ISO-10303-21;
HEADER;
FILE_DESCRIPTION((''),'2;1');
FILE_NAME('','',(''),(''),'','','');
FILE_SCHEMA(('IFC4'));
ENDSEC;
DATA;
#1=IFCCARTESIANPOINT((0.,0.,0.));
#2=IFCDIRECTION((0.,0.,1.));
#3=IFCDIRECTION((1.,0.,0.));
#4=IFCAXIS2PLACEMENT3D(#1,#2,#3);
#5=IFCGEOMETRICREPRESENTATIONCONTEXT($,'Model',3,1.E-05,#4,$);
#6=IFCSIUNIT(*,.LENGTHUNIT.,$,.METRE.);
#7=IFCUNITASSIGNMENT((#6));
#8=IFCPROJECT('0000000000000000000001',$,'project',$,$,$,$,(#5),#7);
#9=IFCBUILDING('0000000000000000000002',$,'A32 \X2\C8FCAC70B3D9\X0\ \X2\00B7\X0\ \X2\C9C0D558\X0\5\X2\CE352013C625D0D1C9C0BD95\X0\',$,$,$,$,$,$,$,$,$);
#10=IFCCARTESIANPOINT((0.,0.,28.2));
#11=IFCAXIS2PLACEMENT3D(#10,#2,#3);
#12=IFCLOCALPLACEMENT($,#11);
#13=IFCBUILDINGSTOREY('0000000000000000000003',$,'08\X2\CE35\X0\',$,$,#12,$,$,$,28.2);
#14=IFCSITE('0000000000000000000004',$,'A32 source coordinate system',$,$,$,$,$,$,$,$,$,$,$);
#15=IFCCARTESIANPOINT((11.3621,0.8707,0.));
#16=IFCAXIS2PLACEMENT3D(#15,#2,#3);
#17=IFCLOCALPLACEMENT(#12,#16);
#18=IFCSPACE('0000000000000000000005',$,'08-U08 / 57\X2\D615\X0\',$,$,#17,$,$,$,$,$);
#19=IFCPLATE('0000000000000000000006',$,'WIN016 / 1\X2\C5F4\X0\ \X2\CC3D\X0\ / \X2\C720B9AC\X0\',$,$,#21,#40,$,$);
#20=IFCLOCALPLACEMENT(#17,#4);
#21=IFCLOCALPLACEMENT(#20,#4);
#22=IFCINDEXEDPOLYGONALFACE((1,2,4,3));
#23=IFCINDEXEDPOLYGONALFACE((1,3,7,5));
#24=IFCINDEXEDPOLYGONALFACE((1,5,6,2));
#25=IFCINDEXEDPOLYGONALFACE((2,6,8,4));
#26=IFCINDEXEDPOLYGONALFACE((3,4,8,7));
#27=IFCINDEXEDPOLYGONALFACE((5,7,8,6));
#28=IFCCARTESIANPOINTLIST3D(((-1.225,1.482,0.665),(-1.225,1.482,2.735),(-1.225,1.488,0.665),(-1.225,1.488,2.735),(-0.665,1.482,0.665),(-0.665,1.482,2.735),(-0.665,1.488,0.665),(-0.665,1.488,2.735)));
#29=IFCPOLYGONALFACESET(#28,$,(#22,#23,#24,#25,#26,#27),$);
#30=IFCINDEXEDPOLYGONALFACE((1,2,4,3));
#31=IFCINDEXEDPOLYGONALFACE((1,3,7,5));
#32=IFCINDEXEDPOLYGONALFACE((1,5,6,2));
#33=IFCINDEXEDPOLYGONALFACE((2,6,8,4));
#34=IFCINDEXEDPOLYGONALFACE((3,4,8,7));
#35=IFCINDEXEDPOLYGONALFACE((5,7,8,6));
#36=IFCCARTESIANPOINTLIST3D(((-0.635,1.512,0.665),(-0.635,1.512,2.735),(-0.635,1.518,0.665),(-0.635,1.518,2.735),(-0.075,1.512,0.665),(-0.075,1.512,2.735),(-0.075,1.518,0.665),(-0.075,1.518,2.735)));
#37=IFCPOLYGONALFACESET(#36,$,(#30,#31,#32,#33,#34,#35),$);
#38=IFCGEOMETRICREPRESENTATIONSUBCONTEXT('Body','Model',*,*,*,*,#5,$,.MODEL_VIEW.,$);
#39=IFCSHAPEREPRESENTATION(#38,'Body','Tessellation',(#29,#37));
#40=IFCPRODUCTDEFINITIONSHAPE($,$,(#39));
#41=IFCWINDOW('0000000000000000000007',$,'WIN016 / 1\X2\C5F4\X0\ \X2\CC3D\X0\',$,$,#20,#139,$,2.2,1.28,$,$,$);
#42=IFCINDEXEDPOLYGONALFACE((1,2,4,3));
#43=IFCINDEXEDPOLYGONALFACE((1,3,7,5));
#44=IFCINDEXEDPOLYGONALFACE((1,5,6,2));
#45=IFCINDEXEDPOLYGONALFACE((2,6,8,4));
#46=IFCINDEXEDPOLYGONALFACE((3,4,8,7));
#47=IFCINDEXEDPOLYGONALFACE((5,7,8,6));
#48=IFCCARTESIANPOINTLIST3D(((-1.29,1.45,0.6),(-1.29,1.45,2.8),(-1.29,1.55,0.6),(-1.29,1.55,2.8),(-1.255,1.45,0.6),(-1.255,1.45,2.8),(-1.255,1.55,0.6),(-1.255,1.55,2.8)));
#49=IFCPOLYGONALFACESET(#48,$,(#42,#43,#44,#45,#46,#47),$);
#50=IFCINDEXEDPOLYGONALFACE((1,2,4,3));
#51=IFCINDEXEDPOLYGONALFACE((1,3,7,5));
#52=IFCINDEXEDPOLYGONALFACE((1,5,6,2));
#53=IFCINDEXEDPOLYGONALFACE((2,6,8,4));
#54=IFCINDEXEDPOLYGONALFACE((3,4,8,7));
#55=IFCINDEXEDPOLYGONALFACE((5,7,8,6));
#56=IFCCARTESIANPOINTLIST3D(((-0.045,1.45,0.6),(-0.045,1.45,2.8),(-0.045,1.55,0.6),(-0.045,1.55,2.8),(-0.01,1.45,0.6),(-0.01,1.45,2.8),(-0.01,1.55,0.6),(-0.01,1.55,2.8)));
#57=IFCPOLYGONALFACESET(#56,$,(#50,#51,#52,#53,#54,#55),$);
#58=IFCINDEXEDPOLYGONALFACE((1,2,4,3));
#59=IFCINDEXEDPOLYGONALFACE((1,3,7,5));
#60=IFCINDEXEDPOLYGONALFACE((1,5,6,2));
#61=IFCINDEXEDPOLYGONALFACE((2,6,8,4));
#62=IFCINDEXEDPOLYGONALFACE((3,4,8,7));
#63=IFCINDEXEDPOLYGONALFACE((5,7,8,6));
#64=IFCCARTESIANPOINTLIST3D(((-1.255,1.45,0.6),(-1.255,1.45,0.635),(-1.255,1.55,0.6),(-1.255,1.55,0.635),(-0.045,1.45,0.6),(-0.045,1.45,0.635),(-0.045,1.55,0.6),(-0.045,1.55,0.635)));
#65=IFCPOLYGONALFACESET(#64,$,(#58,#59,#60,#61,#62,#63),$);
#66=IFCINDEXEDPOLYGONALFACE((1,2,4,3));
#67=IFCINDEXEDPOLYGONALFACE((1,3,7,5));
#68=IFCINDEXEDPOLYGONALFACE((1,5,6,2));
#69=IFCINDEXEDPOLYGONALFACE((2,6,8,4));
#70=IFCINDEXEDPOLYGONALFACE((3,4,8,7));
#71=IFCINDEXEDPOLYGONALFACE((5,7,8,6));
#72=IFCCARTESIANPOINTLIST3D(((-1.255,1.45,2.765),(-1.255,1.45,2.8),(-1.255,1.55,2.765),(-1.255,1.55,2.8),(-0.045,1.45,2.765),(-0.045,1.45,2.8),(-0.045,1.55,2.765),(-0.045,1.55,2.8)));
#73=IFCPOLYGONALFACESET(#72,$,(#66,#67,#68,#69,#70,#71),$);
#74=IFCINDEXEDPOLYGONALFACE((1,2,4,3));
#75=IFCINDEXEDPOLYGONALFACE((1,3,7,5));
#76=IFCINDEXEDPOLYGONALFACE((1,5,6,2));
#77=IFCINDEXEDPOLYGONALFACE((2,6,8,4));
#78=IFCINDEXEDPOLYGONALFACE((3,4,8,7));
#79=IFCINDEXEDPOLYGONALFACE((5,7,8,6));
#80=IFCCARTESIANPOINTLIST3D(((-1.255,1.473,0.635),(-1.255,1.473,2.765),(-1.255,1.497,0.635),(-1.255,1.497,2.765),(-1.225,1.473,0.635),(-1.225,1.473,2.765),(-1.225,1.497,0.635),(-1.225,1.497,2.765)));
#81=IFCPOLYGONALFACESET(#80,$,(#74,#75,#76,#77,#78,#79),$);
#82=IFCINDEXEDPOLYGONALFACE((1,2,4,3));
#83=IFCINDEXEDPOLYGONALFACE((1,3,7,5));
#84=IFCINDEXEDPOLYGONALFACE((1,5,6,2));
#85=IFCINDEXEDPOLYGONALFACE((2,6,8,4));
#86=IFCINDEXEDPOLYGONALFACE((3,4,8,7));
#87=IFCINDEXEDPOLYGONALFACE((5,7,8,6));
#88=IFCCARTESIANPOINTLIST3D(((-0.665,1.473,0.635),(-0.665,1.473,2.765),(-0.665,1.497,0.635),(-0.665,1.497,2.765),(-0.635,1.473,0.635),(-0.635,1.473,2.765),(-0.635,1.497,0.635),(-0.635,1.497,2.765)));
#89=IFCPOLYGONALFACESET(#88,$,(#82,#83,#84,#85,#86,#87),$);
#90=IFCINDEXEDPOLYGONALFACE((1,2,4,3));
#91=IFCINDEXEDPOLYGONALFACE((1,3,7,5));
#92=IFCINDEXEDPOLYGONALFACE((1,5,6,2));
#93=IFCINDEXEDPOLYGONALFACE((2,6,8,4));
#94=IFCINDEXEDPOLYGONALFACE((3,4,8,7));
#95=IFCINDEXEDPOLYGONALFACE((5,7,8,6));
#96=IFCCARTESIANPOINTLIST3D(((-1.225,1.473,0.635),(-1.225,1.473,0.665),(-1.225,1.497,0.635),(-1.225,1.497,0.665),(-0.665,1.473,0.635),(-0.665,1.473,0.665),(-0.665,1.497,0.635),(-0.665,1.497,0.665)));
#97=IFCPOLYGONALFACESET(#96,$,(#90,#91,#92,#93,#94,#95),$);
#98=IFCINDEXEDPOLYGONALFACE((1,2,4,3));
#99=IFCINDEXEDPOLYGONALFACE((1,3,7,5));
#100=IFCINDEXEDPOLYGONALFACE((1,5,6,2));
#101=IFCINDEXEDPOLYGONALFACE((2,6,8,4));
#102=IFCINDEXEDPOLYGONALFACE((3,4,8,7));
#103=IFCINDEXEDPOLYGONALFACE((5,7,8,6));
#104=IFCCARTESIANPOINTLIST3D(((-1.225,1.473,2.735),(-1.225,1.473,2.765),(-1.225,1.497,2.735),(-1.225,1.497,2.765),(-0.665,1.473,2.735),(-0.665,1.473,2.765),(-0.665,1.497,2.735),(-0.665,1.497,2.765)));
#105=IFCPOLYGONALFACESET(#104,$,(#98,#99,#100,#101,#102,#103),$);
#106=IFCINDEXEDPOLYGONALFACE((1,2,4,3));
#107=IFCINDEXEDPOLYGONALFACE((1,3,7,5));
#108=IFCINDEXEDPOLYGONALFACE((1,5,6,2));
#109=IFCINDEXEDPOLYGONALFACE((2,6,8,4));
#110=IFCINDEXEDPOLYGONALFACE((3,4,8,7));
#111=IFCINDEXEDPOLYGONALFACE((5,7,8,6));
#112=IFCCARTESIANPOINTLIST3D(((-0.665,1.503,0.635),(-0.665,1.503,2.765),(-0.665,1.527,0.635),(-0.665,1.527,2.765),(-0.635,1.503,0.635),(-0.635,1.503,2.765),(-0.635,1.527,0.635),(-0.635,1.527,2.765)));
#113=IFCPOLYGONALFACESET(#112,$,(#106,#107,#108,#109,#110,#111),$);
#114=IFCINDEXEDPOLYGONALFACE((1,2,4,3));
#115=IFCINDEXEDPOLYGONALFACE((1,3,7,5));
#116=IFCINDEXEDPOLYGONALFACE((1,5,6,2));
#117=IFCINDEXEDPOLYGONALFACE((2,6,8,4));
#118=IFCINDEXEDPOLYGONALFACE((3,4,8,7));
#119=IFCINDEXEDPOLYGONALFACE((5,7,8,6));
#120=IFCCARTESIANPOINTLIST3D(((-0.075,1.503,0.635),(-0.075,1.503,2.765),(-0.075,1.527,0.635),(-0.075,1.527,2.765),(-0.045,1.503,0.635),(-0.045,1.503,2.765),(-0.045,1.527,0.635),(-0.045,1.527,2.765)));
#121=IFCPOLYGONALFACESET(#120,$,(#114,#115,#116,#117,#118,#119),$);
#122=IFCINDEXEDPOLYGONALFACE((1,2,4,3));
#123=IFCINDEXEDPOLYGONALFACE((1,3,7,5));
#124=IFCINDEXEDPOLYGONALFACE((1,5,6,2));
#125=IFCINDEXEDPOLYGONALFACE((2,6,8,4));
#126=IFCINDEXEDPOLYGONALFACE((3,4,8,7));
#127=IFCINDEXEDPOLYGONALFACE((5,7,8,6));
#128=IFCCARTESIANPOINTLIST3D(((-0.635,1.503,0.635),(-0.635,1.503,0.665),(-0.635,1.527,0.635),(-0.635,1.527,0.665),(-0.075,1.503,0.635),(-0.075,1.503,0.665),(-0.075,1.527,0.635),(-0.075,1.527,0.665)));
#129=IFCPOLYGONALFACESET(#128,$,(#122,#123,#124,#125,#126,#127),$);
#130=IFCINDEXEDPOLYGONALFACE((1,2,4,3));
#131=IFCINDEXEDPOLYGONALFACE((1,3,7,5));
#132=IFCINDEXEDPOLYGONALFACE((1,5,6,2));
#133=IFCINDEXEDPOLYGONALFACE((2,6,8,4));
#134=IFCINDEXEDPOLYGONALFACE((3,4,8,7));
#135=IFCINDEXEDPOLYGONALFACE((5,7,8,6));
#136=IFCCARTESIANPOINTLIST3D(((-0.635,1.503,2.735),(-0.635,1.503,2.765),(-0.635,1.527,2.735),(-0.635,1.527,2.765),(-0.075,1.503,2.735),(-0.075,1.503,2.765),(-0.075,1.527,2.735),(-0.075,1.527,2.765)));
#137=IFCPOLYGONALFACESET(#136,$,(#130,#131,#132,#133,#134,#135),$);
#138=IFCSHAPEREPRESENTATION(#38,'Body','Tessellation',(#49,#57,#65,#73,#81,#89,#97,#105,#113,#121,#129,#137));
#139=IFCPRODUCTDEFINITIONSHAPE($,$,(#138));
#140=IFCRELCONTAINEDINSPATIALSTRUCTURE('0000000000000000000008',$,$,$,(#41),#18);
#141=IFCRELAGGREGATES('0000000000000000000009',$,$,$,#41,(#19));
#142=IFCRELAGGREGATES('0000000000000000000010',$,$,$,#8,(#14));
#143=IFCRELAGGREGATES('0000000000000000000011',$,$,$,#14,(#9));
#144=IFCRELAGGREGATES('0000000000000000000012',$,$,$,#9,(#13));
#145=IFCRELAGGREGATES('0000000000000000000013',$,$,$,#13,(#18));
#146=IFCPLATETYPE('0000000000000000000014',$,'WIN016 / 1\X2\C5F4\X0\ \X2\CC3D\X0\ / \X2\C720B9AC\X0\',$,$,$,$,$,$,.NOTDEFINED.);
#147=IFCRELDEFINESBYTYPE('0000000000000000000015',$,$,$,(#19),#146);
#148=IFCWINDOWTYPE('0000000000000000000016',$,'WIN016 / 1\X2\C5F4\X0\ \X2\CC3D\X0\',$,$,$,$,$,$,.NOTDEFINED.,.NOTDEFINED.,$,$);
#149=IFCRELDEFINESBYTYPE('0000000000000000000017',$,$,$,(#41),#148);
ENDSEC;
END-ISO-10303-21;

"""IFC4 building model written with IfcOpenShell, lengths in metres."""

from ifc_helpers import new_model, si_unit, frame, origin, origin_with_axes, place, context, subcontext, project, spatial, polyline, outline, extrude, source, transform, mapped, type_object, type_shapes, element, aggregate, save


model = new_model("IFC4")

# Units and contexts
model_context = context("Model", 3, precision=1e-05, world=origin_with_axes())
body_context = subcontext(model_context, "Body", "Model", "MODEL_VIEW")
ifc_project = project(units=[si_unit("LENGTHUNIT", "METRE")], contexts=[model_context])

# Plate
storey_placement = place(None, frame((0.0, 0.0, 28.2), z_axis=(0.0, 0.0, 1.0), x_axis=(1.0, 0.0, 0.0)))
space_placement = place(storey_placement, frame((11.3621, 0.8707, 0.0), z_axis=(0.0, 0.0, 1.0), x_axis=(1.0, 0.0, 0.0)))
plate_type_1 = type_object("IfcPlateType", Name="WIN016 / 1열 창 / 유리", PredefinedType="NOTDEFINED")
shared_shape_1 = source(origin(), body_context, "Body", "SweptSolid", [
    extrude(outline(polyline([(-1.225, 1.482), (-1.225, 1.488), (-0.665, 1.488), (-0.665, 1.482), (-1.225, 1.482)])), frame((0.0, 0.0, 0.665)), (0.0, 0.0, 1.0), 2.07),
    extrude(outline(polyline([(-0.635, 1.512), (-0.635, 1.518), (-0.075, 1.518), (-0.075, 1.512), (-0.635, 1.512)])), frame((0.0, 0.0, 0.665)), (0.0, 0.0, 1.0), 2.07),
])
type_shapes(plate_type_1, [shared_shape_1])
window_1_placement = place(space_placement, origin_with_axes())
plate_1_placement = place(window_1_placement, origin_with_axes())
plate_1 = element("IfcPlate", 1, at=plate_1_placement, type_object=plate_type_1, Name="WIN016 / 1열 창 / 유리", context=body_context, shape_type="MappedRepresentation", body=[
    mapped(shared_shape_1, transform((0.0, 0.0, 0.0), scale=1.0)),
])

# Site, building, storey, space
site = spatial("IfcSite", under=ifc_project, Name="A32 source coordinate system")
building = spatial("IfcBuilding", under=site, Name="A32 주거동 · 지하5층–옥탑지붕")
storey = spatial("IfcBuildingStorey", under=building, at=storey_placement, Name="08층", Elevation=28.2)
space = spatial("IfcSpace", under=storey, at=space_placement, Name="08-U08 / 57형")

# Window
window_type_1 = type_object("IfcWindowType", Name="WIN016 / 1열 창", PartitioningType="NOTDEFINED", PredefinedType="NOTDEFINED")
shared_shape_2 = source(origin(), body_context, "Body", "SweptSolid", [
    extrude(outline(polyline([(-1.29, 1.45), (-1.29, 1.55), (-1.255, 1.55), (-1.255, 1.45), (-1.29, 1.45)])), frame((0.0, 0.0, 0.6)), (0.0, 0.0, 1.0), 2.2),
    extrude(outline(polyline([(-0.045, 1.45), (-0.045, 1.55), (-0.01, 1.55), (-0.01, 1.45), (-0.045, 1.45)])), frame((0.0, 0.0, 0.6)), (0.0, 0.0, 1.0), 2.2),
    extrude(outline(polyline([(-1.255, 1.45), (-1.255, 1.55), (-0.045, 1.55), (-0.045, 1.45), (-1.255, 1.45)])), frame((0.0, 0.0, 0.6)), (0.0, 0.0, 1.0), 0.035),
    extrude(outline(polyline([(-1.255, 1.45), (-1.255, 1.55), (-0.045, 1.55), (-0.045, 1.45), (-1.255, 1.45)])), frame((0.0, 0.0, 2.765)), (0.0, 0.0, 1.0), 0.035),
    extrude(outline(polyline([(-1.255, 1.473), (-1.255, 1.497), (-1.225, 1.497), (-1.225, 1.473), (-1.255, 1.473)])), frame((0.0, 0.0, 0.635)), (0.0, 0.0, 1.0), 2.13),
    extrude(outline(polyline([(-0.665, 1.473), (-0.665, 1.497), (-0.635, 1.497), (-0.635, 1.473), (-0.665, 1.473)])), frame((0.0, 0.0, 0.635)), (0.0, 0.0, 1.0), 2.13),
    extrude(outline(polyline([(-1.225, 1.473), (-1.225, 1.497), (-0.665, 1.497), (-0.665, 1.473), (-1.225, 1.473)])), frame((0.0, 0.0, 0.635)), (0.0, 0.0, 1.0), 0.03),
    extrude(outline(polyline([(-1.225, 1.473), (-1.225, 1.497), (-0.665, 1.497), (-0.665, 1.473), (-1.225, 1.473)])), frame((0.0, 0.0, 2.735)), (0.0, 0.0, 1.0), 0.03),
    extrude(outline(polyline([(-0.665, 1.503), (-0.665, 1.527), (-0.635, 1.527), (-0.635, 1.503), (-0.665, 1.503)])), frame((0.0, 0.0, 0.635)), (0.0, 0.0, 1.0), 2.13),
    extrude(outline(polyline([(-0.075, 1.503), (-0.075, 1.527), (-0.045, 1.527), (-0.045, 1.503), (-0.075, 1.503)])), frame((0.0, 0.0, 0.635)), (0.0, 0.0, 1.0), 2.13),
    extrude(outline(polyline([(-0.635, 1.503), (-0.635, 1.527), (-0.075, 1.527), (-0.075, 1.503), (-0.635, 1.503)])), frame((0.0, 0.0, 0.635)), (0.0, 0.0, 1.0), 0.03),
    extrude(outline(polyline([(-0.635, 1.503), (-0.635, 1.527), (-0.075, 1.527), (-0.075, 1.503), (-0.635, 1.503)])), frame((0.0, 0.0, 2.735)), (0.0, 0.0, 1.0), 0.03),
])
type_shapes(window_type_1, [shared_shape_2])
window_1 = element("IfcWindow", 2, at=window_1_placement, inside=space, type_object=window_type_1, Name="WIN016 / 1열 창", OverallHeight=2.2, OverallWidth=1.28, context=body_context, shape_type="MappedRepresentation", body=[
    mapped(shared_shape_2, transform((0.0, 0.0, 0.0), scale=1.0)),
])
aggregate(window_1, [plate_1])

save(model, "model.ifc")
